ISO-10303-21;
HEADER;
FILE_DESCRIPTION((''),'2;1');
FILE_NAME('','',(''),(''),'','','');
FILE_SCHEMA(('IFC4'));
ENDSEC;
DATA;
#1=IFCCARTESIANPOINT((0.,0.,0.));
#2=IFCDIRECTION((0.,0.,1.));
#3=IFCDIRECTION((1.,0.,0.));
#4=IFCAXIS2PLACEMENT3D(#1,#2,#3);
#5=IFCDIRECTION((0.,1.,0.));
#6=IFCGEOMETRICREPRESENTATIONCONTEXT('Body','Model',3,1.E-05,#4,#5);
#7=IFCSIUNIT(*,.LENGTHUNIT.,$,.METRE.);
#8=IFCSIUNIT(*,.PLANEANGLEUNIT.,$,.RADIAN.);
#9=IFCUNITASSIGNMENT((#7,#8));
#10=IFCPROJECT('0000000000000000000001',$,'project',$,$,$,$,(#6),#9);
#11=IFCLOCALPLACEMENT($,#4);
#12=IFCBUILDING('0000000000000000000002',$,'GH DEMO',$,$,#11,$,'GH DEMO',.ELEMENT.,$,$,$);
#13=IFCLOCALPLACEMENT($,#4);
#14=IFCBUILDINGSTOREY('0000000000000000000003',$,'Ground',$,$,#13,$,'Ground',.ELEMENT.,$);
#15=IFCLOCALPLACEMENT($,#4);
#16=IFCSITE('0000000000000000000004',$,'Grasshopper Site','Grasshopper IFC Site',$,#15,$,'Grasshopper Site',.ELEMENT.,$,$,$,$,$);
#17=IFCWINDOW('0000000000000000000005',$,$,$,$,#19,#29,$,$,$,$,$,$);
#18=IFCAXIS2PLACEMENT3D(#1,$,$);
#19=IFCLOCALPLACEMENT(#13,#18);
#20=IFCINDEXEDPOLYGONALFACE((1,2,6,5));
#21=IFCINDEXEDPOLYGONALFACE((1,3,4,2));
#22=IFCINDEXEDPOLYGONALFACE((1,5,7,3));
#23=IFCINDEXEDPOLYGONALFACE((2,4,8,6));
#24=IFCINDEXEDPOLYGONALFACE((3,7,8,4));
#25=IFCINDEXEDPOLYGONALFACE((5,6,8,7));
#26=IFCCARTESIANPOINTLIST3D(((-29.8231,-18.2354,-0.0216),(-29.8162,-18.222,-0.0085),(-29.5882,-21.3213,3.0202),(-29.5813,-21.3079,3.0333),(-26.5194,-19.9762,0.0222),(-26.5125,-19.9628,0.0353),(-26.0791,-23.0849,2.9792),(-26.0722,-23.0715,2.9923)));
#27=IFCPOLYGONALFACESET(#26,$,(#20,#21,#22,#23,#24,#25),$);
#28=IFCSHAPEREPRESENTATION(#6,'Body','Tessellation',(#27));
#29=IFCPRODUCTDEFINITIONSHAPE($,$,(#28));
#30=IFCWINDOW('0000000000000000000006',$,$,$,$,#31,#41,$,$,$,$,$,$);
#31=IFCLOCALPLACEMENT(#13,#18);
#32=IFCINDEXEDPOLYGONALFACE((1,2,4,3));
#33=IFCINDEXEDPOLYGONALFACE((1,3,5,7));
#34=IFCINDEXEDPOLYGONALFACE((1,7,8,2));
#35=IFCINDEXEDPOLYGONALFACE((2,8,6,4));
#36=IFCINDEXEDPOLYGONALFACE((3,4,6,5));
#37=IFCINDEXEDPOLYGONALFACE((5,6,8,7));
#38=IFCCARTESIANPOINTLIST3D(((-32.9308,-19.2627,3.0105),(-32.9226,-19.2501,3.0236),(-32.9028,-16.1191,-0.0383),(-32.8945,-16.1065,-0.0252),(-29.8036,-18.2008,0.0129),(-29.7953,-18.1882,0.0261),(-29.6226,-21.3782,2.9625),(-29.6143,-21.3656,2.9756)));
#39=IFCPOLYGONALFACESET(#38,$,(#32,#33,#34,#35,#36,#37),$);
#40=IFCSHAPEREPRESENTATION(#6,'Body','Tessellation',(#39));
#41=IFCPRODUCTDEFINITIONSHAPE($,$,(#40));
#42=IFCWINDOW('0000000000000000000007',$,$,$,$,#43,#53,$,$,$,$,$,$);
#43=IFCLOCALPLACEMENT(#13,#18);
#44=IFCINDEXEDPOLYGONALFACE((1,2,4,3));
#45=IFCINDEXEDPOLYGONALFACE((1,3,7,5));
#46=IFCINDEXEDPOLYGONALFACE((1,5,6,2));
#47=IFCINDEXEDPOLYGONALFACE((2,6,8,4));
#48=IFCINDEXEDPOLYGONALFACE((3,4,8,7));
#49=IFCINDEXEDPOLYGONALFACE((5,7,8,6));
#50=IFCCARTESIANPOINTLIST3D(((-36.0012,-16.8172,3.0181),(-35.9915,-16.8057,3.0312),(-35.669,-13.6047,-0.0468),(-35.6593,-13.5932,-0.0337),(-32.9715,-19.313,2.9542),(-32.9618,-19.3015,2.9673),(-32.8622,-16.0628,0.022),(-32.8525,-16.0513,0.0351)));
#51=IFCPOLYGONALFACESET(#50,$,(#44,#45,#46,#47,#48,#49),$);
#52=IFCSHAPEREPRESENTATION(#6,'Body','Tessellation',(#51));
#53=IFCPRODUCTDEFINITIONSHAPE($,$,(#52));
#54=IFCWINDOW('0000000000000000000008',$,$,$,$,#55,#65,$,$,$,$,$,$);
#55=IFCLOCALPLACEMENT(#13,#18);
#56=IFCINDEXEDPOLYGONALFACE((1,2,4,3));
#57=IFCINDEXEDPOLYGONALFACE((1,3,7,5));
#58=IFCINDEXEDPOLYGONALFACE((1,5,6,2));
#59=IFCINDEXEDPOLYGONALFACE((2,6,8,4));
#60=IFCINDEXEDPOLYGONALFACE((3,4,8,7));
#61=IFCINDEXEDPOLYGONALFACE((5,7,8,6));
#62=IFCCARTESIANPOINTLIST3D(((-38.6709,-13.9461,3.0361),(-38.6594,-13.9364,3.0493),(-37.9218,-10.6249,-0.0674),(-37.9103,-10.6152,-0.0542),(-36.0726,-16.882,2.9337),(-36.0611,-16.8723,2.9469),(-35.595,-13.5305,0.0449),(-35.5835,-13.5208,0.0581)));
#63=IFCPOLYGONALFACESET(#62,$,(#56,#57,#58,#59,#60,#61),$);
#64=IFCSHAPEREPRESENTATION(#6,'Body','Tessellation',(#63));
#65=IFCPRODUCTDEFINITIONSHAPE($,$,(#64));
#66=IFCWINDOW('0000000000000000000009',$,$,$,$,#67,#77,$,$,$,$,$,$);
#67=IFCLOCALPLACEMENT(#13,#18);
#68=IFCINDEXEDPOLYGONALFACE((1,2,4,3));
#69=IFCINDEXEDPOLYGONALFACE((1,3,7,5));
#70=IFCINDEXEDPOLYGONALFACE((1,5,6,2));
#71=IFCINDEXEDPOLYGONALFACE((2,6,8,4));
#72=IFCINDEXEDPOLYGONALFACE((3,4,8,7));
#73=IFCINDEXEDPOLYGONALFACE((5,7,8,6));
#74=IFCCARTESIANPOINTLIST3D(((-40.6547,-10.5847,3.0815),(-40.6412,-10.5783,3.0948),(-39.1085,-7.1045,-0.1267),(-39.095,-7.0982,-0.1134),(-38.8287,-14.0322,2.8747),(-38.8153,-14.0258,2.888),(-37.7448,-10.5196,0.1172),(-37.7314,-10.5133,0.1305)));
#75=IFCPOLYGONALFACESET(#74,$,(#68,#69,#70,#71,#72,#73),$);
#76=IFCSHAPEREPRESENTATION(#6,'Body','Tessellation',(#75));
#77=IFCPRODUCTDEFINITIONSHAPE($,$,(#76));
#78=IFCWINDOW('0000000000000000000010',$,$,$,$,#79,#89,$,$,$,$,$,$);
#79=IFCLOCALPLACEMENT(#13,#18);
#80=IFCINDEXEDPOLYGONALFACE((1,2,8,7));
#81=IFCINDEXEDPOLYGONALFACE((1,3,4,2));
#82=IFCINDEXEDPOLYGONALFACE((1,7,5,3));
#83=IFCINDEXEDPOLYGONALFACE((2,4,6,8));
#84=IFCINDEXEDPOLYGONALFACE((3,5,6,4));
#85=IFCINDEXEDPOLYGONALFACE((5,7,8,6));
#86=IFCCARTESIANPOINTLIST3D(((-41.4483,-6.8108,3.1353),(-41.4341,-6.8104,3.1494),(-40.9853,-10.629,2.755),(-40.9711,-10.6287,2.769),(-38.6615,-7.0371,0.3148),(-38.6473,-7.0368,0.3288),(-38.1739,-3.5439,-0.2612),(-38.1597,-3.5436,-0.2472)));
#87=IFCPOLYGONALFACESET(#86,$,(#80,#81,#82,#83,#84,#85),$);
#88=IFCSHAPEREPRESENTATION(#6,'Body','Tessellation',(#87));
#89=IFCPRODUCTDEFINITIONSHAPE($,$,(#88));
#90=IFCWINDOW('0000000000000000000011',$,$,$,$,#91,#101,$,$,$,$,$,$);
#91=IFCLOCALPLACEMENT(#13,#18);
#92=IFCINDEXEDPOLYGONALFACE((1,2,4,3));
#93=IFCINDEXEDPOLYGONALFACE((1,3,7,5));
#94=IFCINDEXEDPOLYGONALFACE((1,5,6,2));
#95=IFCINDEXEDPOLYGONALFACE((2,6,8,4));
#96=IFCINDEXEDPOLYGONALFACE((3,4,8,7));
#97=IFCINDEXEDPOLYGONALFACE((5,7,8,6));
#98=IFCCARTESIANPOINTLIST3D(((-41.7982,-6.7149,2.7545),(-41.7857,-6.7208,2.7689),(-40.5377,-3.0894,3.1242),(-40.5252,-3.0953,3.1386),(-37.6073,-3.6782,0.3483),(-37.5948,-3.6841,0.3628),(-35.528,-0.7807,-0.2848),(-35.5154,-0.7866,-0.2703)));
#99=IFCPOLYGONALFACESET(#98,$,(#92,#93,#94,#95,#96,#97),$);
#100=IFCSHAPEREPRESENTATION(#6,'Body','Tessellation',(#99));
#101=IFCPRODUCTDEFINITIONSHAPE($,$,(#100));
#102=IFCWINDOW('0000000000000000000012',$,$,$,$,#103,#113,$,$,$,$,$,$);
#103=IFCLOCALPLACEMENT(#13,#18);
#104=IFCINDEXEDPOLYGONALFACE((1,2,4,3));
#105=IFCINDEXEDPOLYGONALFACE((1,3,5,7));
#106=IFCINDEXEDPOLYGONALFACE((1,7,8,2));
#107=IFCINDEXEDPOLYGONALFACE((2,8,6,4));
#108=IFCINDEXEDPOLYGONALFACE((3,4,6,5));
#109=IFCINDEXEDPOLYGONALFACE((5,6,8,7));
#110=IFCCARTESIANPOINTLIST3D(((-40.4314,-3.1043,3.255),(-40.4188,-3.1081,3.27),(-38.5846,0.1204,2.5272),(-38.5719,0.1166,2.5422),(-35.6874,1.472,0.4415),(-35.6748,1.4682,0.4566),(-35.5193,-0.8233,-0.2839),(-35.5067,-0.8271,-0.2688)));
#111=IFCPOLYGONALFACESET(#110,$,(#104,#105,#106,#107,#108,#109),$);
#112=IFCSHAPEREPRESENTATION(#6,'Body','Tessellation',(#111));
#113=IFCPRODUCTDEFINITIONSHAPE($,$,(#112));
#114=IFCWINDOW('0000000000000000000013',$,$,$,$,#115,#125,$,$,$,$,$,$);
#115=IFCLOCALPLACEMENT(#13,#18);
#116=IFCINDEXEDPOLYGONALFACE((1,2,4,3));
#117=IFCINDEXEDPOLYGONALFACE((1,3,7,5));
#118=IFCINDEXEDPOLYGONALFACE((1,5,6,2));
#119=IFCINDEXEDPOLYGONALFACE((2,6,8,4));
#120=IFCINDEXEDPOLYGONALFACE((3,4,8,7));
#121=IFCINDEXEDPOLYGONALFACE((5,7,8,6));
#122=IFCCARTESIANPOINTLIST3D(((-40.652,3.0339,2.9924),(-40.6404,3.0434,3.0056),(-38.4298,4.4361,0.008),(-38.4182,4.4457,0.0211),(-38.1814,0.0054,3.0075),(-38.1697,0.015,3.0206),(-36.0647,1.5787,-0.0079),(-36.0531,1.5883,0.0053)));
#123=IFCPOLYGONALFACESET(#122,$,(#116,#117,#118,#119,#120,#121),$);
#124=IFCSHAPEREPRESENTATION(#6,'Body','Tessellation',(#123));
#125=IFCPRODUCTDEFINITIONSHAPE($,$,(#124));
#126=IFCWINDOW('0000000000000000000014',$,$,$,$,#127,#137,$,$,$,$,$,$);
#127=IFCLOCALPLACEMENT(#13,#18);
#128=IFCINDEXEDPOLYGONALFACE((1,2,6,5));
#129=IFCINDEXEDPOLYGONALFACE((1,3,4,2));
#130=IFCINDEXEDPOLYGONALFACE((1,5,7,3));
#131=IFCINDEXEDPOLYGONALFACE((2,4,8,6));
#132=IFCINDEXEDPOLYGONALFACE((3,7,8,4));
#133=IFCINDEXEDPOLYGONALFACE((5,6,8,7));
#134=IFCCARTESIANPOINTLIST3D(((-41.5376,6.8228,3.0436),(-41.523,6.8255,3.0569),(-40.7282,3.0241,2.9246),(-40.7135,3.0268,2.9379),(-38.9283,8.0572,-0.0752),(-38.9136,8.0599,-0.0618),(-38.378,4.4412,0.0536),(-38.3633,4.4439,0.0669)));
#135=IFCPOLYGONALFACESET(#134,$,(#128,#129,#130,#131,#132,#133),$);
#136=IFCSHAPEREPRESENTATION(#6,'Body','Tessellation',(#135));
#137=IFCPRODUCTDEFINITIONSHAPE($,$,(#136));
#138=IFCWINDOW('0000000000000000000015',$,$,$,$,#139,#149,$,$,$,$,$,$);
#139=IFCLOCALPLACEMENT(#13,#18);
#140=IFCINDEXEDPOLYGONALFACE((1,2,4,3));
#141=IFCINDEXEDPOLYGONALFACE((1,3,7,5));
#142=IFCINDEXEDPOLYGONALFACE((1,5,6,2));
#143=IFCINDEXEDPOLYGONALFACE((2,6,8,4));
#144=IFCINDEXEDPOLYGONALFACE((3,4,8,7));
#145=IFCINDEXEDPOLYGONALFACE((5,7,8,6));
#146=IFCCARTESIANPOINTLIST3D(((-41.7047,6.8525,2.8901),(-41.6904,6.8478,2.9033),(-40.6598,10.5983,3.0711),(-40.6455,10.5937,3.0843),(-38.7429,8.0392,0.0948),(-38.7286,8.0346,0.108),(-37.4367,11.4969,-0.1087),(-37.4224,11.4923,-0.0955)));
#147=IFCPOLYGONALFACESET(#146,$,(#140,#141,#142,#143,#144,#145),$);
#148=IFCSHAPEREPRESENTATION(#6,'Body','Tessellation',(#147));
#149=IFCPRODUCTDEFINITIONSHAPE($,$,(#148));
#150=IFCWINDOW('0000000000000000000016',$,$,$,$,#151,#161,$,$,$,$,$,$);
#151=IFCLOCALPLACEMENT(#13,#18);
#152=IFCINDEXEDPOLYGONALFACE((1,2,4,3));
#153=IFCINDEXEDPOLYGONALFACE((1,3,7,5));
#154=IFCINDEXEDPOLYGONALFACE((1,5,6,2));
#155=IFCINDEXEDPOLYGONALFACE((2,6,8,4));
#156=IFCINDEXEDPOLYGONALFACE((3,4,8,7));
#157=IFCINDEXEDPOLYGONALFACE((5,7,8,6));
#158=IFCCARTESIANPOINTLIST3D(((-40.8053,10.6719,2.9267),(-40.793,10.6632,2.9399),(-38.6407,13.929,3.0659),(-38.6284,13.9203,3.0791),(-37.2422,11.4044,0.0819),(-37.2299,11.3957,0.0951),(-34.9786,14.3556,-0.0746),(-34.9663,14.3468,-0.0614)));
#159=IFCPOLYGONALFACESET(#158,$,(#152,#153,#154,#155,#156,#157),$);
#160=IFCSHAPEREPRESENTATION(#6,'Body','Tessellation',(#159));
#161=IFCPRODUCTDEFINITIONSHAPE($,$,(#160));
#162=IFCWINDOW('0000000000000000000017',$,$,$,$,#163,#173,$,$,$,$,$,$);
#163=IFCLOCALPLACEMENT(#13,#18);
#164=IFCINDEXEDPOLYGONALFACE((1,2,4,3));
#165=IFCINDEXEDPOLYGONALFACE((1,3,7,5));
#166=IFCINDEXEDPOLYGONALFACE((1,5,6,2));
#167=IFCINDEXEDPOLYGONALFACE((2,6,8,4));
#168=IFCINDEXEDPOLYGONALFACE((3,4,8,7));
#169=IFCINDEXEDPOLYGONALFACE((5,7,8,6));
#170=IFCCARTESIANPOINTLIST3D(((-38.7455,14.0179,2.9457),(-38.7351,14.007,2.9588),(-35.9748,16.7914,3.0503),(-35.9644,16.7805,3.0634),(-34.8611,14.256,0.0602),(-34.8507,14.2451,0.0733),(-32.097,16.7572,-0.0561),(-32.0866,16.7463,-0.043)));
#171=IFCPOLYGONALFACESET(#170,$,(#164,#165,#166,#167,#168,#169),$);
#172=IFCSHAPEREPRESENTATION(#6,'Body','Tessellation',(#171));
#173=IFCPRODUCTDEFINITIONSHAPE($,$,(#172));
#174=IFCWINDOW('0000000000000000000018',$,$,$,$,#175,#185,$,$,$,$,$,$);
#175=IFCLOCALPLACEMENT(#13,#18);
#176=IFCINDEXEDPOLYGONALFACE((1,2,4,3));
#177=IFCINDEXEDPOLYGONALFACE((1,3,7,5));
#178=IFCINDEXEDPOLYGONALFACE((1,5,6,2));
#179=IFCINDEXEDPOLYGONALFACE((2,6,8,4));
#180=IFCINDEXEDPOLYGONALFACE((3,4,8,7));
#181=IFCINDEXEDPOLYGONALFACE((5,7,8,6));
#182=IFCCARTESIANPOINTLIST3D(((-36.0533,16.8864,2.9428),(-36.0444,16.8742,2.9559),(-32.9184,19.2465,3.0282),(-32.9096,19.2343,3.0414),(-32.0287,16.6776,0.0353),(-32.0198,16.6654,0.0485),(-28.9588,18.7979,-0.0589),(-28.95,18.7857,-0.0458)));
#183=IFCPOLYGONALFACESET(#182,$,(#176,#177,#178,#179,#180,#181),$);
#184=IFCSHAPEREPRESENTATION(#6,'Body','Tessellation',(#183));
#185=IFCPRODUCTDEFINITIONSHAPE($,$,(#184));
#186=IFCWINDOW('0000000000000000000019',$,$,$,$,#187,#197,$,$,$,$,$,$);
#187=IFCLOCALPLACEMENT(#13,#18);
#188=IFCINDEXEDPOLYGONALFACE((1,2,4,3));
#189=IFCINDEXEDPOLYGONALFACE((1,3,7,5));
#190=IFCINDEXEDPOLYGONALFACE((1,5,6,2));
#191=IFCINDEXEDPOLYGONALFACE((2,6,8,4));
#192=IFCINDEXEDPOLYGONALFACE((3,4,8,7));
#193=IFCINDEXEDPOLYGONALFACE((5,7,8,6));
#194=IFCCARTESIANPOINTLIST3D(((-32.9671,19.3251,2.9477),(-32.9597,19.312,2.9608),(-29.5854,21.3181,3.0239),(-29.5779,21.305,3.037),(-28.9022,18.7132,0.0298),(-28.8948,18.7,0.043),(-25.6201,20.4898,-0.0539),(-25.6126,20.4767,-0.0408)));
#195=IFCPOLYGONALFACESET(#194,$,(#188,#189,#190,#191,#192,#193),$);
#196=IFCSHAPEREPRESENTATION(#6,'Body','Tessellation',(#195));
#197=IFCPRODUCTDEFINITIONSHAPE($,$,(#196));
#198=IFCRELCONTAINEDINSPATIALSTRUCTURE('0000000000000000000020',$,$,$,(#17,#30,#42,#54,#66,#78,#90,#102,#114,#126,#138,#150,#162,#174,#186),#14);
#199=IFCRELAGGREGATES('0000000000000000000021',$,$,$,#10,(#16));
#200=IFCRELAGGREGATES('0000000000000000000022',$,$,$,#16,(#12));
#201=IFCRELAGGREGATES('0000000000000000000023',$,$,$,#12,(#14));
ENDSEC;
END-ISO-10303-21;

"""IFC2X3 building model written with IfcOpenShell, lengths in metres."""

from ifc_helpers import new_model, si_unit, direction, frame, origin_with_axes, place, context, project, spatial, polyline, outline, extrude, element, save


model = new_model("IFC2X3")

# Units and contexts
model_context = context("Model", 3, precision=1e-05, world=origin_with_axes(), true_north=direction((0.0, 1.0, 0.0)), identifier="Body")
ifc_project = project(units=[si_unit("LENGTHUNIT", "METRE"), si_unit("PLANEANGLEUNIT", "RADIAN")], contexts=[model_context])

# Site, building, storey
site_placement = place(None, origin_with_axes())
site = spatial("IfcSite", under=ifc_project, at=site_placement, Name="Grasshopper Site", Description="Grasshopper IFC Site", LongName="Grasshopper Site", CompositionType="ELEMENT")
building_placement = place(None, origin_with_axes())
building = spatial("IfcBuilding", under=site, at=building_placement, Name="GH DEMO", LongName="GH DEMO", CompositionType="ELEMENT")
storey_placement = place(None, origin_with_axes())
storey = spatial("IfcBuildingStorey", under=building, at=storey_placement, Name="Ground", LongName="Ground", CompositionType="ELEMENT")

# Windows
window_1_placement = place(None, origin_with_axes())
element("IfcWindow", 1, at=window_1_placement, inside=storey, context=model_context, shape_type="SweptSolid", body=[
    extrude(outline(polyline([(0.0, 0.0), (4.3129, 0.0), (2.7117, 3.5864), (-1.622, 3.3639), (0.0, 0.0)])), frame((-26.5194, -19.9762, 0.0222), z_axis=(-0.34541, -0.672005, -0.655058), x_axis=(0.102078, -0.720782, 0.685604)), (0.0, 0.0, -1.0), 0.02),
])
window_2_placement = place(None, origin_with_axes())
element("IfcWindow", 2, at=window_2_placement, inside=storey, context=model_context, shape_type="SweptSolid", body=[
    extrude(outline(polyline([(0.0, 0.0), (4.3392, 0.0), (2.6847, 3.5616), (-1.6885, 3.3302), (0.0, 0.0)])), frame((-29.7953, -18.1882, 0.0261), z_axis=(-0.413629, -0.631953, -0.655398), x_axis=(0.041706, -0.732262, 0.679745)), (0.0, 0.0, 1.0), 0.02),
])
window_3_placement = place(None, origin_with_axes())
element("IfcWindow", 3, at=window_3_placement, inside=storey, context=model_context, shape_type="SweptSolid", body=[
    extrude(outline(polyline([(0.0, 0.0), (4.3787, 0.0), (2.6446, 3.5221), (-1.8006, 3.2685), (0.0, 0.0)])), frame((-32.8525, -16.0513, 0.0351), z_axis=(-0.487988, -0.575572, -0.656189), x_axis=(-0.024965, -0.742267, 0.66964)), (0.0, 0.0, 1.0), 0.02),
])
window_4_placement = place(None, origin_with_axes())
element("IfcWindow", 4, at=window_4_placement, inside=storey, context=model_context, shape_type="SweptSolid", body=[
    extrude(outline(polyline([(0.0, 0.0), (4.4504, 0.0), (2.5847, 3.4497), (-2.0114, 3.1342), (0.0, 0.0)])), frame((-35.5835, -13.5208, 0.0581), z_axis=(-0.574794, -0.485726, -0.658545), x_axis=(-0.107304, -0.753085, 0.649114)), (0.0, 0.0, 1.0), 0.02),
])
window_5_placement = place(None, origin_with_axes())
element("IfcWindow", 5, at=window_5_placement, inside=storey, context=model_context, shape_type="SweptSolid", body=[
    extrude(outline(polyline([(0.0, 0.0), (4.5953, 0.0), (2.5149, 3.3067), (-2.4351, 2.7662), (0.0, 0.0)])), frame((-37.7314, -10.5133, 0.1305), z_axis=(-0.673439, -0.31661, -0.66801), x_axis=(-0.235871, -0.76438, 0.600073)), (0.0, 0.0, 1.0), 0.02),
])
window_6_placement = place(None, origin_with_axes())
element("IfcWindow", 6, at=window_6_placement, inside=storey, context=model_context, shape_type="SweptSolid", body=[
    extrude(outline(polyline([(0.0, 0.0), (4.925, 0.0), (2.5473, 3.047), (-3.0631, 1.8411), (0.0, 0.0)])), frame((-38.6473, -7.0368, 0.3288), z_axis=(-0.711914, -0.016394, -0.702076), x_axis=(-0.471826, -0.72931, 0.495467)), (0.0, 0.0, 1.0), 0.02),
])
window_7_placement = place(None, origin_with_axes())
element("IfcWindow", 7, at=window_7_placement, inside=storey, context=model_context, shape_type="SweptSolid", body=[
    extrude(outline(polyline([(0.0, 0.0), (5.7074, 0.0), (3.0087, 2.7544), (-3.3354, 1.4125), (0.0, 0.0)])), frame((-37.5948, -3.6841, 0.3628), z_axis=(-0.626319, 0.291483, -0.723023), x_axis=(-0.734289, -0.532061, 0.421581)), (0.0, 0.0, 1.0), 0.02),
])
window_8_placement = place(None, origin_with_axes())
element("IfcWindow", 8, at=window_8_placement, inside=storey, context=model_context, shape_type="SweptSolid", body=[
    extrude(outline(polyline([(0.0, 0.0), (6.4696, 0.0), (3.5322, 2.3898), (-0.2849, 2.3961), (0.0, 0.0)])), frame((-35.5067, -0.8271, -0.2688), z_axis=(-0.630711, 0.191495, -0.75202), x_axis=(-0.75926, -0.35258, 0.547002)), (0.0, 0.0, 1.0), 0.02),
])
window_9_placement = place(None, origin_with_axes())
element("IfcWindow", 9, at=window_9_placement, inside=storey, context=model_context, shape_type="SweptSolid", body=[
    extrude(outline(polyline([(0.0, 0.0), (4.006, 0.0), (4.1108, 3.907), (0.1395, 3.7067), (0.0, 0.0)])), frame((-36.0647, 1.5787, -0.0079), z_axis=(-0.581941, -0.478026, -0.657903), x_axis=(-0.528377, -0.392723, 0.752719)), (0.0, 0.0, -1.0), 0.02),
])
window_10_placement = place(None, origin_with_axes())
element("IfcWindow", 10, at=window_10_placement, inside=storey, context=model_context, shape_type="SweptSolid", body=[
    extrude(outline(polyline([(0.0, 0.0), (3.9717, 0.0), (3.1813, 3.8046), (-1.0577, 3.5038), (0.0, 0.0)])), frame((-38.3633, 4.4439, 0.0669), z_axis=(-0.732908, -0.135283, -0.666742), x_axis=(-0.591741, -0.356809, 0.722862)), (0.0, 0.0, 1.0), 0.02),
])
window_11_placement = place(None, origin_with_axes())
element("IfcWindow", 11, at=window_11_placement, inside=storey, context=model_context, shape_type="SweptSolid", body=[
    extrude(outline(polyline([(0.0, 0.0), (4.242, 0.0), (2.5837, 3.5223), (-2.0134, 3.1064), (0.0, 0.0)])), frame((-38.7286, 8.0346, 0.108), z_axis=(-0.715186, 0.231353, -0.659534), x_axis=(-0.698199, -0.279764, 0.658977)), (0.0, 0.0, 1.0), 0.02),
])
window_12_placement = place(None, origin_with_axes())
element("IfcWindow", 12, at=window_12_placement, inside=storey, context=model_context, shape_type="SweptSolid", body=[
    extrude(outline(polyline([(0.0, 0.0), (4.6179, 0.0), (2.5169, 3.3014), (-2.3111, 2.9184), (0.0, 0.0)])), frame((-37.2422, 11.4044, 0.0819), z_axis=(-0.614461, 0.436451, -0.657228), x_axis=(-0.771581, -0.158615, 0.616039)), (0.0, 0.0, -1.0), 0.02),
])
window_13_placement = place(None, origin_with_axes())
element("IfcWindow", 13, at=window_13_placement, inside=storey, context=model_context, shape_type="SweptSolid", body=[
    extrude(outline(polyline([(0.0, 0.0), (4.8447, 0.0), (2.5492, 3.1797), (-2.4084, 2.8476), (0.0, 0.0)])), frame((-34.8611, 14.256, 0.0602), z_axis=(-0.521115, 0.545356, -0.656526), x_axis=(-0.801786, -0.049149, 0.595587)), (0.0, 0.0, -1.0), 0.02),
])
window_14_placement = place(None, origin_with_axes())
element("IfcWindow", 14, at=window_14_placement, inside=storey, context=model_context, shape_type="SweptSolid", body=[
    extrude(outline(polyline([(0.0, 0.0), (4.9693, 0.0), (2.5796, 3.1135), (-2.4523, 2.8133), (0.0, 0.0)])), frame((-32.0198, 16.6654, 0.0485), z_axis=(-0.442357, 0.611313, -0.656214), x_axis=(-0.809884, 0.042013, 0.585084)), (0.0, 0.0, 1.0), 0.02),
])
window_15_placement = place(None, origin_with_axes())
element("IfcWindow", 15, at=window_15_placement, inside=storey, context=model_context, shape_type="SweptSolid", body=[
    extrude(outline(polyline([(0.0, 0.0), (5.041, 0.0), (2.6002, 3.0751), (-2.4794, 2.7907), (0.0, 0.0)])), frame((-28.8948, 18.7, 0.043), z_axis=(-0.37213, 0.656532, -0.656114), x_axis=(-0.806367, 0.121396, 0.578822)), (0.0, 0.0, 1.0), 0.02),
])

save(model, "model.ifc")
